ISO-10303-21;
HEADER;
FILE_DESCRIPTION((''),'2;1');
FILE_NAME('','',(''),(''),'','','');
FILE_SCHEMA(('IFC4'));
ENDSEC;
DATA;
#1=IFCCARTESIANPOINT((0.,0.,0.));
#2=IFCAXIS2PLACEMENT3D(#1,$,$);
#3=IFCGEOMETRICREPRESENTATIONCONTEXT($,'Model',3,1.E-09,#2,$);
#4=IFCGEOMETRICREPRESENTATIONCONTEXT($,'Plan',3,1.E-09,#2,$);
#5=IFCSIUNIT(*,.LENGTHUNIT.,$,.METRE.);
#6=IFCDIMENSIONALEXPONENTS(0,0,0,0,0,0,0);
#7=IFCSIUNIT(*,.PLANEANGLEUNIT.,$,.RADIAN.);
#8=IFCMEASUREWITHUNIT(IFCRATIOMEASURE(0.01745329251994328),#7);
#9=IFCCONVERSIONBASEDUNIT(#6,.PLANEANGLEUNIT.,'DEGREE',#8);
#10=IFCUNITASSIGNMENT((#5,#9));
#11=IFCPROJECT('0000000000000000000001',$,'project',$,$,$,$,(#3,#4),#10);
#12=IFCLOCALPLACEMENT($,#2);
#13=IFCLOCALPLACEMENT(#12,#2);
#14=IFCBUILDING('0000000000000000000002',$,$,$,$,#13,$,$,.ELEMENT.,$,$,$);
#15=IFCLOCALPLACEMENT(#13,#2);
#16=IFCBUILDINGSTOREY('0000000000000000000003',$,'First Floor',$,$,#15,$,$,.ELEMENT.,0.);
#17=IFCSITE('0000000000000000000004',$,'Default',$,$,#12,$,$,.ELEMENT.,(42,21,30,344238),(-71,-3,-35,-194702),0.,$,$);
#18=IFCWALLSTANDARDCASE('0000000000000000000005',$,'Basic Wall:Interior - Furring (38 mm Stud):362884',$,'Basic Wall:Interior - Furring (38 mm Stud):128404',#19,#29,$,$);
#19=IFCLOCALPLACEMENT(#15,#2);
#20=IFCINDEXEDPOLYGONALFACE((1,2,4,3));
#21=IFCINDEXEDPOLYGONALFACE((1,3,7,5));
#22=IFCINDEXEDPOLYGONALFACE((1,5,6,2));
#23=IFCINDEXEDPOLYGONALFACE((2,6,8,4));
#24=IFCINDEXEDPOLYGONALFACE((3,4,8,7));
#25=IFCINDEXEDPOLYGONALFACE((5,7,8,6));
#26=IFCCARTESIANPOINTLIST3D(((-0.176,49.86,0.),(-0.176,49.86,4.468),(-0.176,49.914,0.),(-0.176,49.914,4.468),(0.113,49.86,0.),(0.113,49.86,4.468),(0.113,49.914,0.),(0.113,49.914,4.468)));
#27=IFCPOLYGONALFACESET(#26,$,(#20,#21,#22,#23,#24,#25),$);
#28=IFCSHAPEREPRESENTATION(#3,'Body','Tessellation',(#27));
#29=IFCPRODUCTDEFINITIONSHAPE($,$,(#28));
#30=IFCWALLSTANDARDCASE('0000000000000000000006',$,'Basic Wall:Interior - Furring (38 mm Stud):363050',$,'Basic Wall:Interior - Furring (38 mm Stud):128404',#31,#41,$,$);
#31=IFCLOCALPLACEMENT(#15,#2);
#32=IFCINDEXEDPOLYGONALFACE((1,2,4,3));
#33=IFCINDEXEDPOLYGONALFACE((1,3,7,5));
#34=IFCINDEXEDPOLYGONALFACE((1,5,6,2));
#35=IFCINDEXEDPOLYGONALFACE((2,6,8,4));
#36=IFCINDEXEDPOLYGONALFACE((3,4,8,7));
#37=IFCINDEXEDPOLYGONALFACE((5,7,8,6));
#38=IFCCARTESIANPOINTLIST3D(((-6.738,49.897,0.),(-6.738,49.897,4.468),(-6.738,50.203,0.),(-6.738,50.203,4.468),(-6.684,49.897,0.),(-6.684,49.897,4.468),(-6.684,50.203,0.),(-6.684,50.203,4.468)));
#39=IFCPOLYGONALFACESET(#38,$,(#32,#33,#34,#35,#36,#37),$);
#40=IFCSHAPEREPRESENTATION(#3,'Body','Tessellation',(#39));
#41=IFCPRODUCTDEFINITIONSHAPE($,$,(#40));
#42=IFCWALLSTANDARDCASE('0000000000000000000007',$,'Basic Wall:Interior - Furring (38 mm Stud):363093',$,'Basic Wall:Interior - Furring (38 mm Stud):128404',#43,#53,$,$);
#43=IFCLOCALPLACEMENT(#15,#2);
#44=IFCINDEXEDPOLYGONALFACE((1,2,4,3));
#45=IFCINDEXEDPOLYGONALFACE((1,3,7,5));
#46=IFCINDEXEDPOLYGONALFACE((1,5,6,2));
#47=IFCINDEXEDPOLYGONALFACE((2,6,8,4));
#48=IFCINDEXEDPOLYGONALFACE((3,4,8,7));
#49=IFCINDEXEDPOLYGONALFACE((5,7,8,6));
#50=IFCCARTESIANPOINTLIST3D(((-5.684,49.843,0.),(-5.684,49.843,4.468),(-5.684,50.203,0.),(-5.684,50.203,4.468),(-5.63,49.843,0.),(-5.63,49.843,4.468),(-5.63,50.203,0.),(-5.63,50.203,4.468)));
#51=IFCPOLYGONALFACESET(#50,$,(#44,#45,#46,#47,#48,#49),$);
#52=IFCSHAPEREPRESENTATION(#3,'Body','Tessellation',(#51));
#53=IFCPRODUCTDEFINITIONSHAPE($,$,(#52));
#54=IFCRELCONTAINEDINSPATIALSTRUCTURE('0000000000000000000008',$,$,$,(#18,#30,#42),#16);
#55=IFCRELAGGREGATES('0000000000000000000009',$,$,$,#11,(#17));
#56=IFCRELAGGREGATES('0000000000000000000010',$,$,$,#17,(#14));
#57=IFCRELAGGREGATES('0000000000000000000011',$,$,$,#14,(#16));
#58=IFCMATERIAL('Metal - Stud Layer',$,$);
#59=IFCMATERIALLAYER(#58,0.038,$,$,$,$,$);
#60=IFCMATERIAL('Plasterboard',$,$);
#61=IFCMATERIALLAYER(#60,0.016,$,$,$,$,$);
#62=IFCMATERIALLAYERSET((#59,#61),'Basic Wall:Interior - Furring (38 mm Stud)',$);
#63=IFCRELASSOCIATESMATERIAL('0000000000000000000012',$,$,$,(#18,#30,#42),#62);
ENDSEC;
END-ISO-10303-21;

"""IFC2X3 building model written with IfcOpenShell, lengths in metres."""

from ifc_helpers import new_model, entity, si_unit, converted_unit, frame, frame_2d, origin, place, context, project, spatial, rectangle, extrude, material, layer, layer_set, layer_usage, element, save


model = new_model("IFC2X3")

# Units and contexts
model_context = context("Model", 3, precision=1e-09, world=origin())
plan_context = context("Plan", 3, precision=1e-09, world=origin())
ifc_project = project(units=[si_unit("LENGTHUNIT", "METRE"), converted_unit("PLANEANGLEUNIT", "DEGREE", entity("IfcRatioMeasure", 0.01745329251994328), si_unit("PLANEANGLEUNIT", "RADIAN"), dimensions=[0, 0, 0, 0, 0, 0, 0])], contexts=[model_context, plan_context])

# Site, building, storey
site_placement = place(None, origin())
site = spatial("IfcSite", under=ifc_project, at=site_placement, Name="Default", CompositionType="ELEMENT", RefLatitude=(42, 21, 30, 344238), RefLongitude=(-71, -3, -35, -194702), RefElevation=0.0)
building_placement = place(site_placement, origin())
building = spatial("IfcBuilding", under=site, at=building_placement, CompositionType="ELEMENT")
storey_placement = place(building_placement, origin())
storey = spatial("IfcBuildingStorey", under=building, at=storey_placement, Name="First Floor", CompositionType="ELEMENT", Elevation=0.0)

# Shared definitions
ifc_material_1 = material(Name="Metal - Stud Layer")
ifc_material_2 = material(Name="Plasterboard")
ifc_layer_1 = layer(ifc_material_2, 0.016)

# Walls
ifc_layer_2 = layer(ifc_material_1, 0.038)
ifc_layer_set_1 = layer_set([ifc_layer_2, ifc_layer_1], Name="Basic Wall:Interior - Furring (38 mm Stud)")
ifc_layer_usage_1 = layer_usage(ifc_layer_set_1, "AXIS2", "NEGATIVE", 0.027)
wall_1_placement = place(storey_placement, frame((-0.176, 49.887, 0.0)))
element("IfcWallStandardCase", 1, at=wall_1_placement, inside=storey, material=ifc_layer_usage_1, Name="Basic Wall:Interior - Furring (38 mm Stud):362884", ObjectType="Basic Wall:Interior - Furring (38 mm Stud):128404", context=model_context, shape_type="SweptSolid", body=[
    extrude(rectangle(XDim=0.289, YDim=0.054, at=frame_2d((0.1445, 0.0), x_axis=(-1.0, 0.0))), origin(), (0.0, 0.0, 1.0), 4.468),
])
wall_2_placement = place(storey_placement, frame((-6.711, 49.897, 0.0), z_axis=(0.0, 0.0, 1.0), x_axis=(0.0, 1.0, 0.0)))
element("IfcWallStandardCase", 2, at=wall_2_placement, inside=storey, material=ifc_layer_usage_1, Name="Basic Wall:Interior - Furring (38 mm Stud):363050", ObjectType="Basic Wall:Interior - Furring (38 mm Stud):128404", context=model_context, shape_type="SweptSolid", body=[
    extrude(rectangle(XDim=0.306, YDim=0.054, at=frame_2d((0.153, 0.0), x_axis=(-1.0, 0.0))), origin(), (0.0, 0.0, 1.0), 4.468),
])
wall_3_placement = place(storey_placement, frame((-5.657, 50.203, 0.0), z_axis=(0.0, 0.0, 1.0), x_axis=(0.0, -1.0, 0.0)))
element("IfcWallStandardCase", 3, at=wall_3_placement, inside=storey, material=ifc_layer_usage_1, Name="Basic Wall:Interior - Furring (38 mm Stud):363093", ObjectType="Basic Wall:Interior - Furring (38 mm Stud):128404", context=model_context, shape_type="SweptSolid", body=[
    extrude(rectangle(XDim=0.36, YDim=0.054, at=frame_2d((0.18, 0.0), x_axis=(-1.0, 0.0))), origin(), (0.0, 0.0, 1.0), 4.468),
])

save(model, "model.ifc")
